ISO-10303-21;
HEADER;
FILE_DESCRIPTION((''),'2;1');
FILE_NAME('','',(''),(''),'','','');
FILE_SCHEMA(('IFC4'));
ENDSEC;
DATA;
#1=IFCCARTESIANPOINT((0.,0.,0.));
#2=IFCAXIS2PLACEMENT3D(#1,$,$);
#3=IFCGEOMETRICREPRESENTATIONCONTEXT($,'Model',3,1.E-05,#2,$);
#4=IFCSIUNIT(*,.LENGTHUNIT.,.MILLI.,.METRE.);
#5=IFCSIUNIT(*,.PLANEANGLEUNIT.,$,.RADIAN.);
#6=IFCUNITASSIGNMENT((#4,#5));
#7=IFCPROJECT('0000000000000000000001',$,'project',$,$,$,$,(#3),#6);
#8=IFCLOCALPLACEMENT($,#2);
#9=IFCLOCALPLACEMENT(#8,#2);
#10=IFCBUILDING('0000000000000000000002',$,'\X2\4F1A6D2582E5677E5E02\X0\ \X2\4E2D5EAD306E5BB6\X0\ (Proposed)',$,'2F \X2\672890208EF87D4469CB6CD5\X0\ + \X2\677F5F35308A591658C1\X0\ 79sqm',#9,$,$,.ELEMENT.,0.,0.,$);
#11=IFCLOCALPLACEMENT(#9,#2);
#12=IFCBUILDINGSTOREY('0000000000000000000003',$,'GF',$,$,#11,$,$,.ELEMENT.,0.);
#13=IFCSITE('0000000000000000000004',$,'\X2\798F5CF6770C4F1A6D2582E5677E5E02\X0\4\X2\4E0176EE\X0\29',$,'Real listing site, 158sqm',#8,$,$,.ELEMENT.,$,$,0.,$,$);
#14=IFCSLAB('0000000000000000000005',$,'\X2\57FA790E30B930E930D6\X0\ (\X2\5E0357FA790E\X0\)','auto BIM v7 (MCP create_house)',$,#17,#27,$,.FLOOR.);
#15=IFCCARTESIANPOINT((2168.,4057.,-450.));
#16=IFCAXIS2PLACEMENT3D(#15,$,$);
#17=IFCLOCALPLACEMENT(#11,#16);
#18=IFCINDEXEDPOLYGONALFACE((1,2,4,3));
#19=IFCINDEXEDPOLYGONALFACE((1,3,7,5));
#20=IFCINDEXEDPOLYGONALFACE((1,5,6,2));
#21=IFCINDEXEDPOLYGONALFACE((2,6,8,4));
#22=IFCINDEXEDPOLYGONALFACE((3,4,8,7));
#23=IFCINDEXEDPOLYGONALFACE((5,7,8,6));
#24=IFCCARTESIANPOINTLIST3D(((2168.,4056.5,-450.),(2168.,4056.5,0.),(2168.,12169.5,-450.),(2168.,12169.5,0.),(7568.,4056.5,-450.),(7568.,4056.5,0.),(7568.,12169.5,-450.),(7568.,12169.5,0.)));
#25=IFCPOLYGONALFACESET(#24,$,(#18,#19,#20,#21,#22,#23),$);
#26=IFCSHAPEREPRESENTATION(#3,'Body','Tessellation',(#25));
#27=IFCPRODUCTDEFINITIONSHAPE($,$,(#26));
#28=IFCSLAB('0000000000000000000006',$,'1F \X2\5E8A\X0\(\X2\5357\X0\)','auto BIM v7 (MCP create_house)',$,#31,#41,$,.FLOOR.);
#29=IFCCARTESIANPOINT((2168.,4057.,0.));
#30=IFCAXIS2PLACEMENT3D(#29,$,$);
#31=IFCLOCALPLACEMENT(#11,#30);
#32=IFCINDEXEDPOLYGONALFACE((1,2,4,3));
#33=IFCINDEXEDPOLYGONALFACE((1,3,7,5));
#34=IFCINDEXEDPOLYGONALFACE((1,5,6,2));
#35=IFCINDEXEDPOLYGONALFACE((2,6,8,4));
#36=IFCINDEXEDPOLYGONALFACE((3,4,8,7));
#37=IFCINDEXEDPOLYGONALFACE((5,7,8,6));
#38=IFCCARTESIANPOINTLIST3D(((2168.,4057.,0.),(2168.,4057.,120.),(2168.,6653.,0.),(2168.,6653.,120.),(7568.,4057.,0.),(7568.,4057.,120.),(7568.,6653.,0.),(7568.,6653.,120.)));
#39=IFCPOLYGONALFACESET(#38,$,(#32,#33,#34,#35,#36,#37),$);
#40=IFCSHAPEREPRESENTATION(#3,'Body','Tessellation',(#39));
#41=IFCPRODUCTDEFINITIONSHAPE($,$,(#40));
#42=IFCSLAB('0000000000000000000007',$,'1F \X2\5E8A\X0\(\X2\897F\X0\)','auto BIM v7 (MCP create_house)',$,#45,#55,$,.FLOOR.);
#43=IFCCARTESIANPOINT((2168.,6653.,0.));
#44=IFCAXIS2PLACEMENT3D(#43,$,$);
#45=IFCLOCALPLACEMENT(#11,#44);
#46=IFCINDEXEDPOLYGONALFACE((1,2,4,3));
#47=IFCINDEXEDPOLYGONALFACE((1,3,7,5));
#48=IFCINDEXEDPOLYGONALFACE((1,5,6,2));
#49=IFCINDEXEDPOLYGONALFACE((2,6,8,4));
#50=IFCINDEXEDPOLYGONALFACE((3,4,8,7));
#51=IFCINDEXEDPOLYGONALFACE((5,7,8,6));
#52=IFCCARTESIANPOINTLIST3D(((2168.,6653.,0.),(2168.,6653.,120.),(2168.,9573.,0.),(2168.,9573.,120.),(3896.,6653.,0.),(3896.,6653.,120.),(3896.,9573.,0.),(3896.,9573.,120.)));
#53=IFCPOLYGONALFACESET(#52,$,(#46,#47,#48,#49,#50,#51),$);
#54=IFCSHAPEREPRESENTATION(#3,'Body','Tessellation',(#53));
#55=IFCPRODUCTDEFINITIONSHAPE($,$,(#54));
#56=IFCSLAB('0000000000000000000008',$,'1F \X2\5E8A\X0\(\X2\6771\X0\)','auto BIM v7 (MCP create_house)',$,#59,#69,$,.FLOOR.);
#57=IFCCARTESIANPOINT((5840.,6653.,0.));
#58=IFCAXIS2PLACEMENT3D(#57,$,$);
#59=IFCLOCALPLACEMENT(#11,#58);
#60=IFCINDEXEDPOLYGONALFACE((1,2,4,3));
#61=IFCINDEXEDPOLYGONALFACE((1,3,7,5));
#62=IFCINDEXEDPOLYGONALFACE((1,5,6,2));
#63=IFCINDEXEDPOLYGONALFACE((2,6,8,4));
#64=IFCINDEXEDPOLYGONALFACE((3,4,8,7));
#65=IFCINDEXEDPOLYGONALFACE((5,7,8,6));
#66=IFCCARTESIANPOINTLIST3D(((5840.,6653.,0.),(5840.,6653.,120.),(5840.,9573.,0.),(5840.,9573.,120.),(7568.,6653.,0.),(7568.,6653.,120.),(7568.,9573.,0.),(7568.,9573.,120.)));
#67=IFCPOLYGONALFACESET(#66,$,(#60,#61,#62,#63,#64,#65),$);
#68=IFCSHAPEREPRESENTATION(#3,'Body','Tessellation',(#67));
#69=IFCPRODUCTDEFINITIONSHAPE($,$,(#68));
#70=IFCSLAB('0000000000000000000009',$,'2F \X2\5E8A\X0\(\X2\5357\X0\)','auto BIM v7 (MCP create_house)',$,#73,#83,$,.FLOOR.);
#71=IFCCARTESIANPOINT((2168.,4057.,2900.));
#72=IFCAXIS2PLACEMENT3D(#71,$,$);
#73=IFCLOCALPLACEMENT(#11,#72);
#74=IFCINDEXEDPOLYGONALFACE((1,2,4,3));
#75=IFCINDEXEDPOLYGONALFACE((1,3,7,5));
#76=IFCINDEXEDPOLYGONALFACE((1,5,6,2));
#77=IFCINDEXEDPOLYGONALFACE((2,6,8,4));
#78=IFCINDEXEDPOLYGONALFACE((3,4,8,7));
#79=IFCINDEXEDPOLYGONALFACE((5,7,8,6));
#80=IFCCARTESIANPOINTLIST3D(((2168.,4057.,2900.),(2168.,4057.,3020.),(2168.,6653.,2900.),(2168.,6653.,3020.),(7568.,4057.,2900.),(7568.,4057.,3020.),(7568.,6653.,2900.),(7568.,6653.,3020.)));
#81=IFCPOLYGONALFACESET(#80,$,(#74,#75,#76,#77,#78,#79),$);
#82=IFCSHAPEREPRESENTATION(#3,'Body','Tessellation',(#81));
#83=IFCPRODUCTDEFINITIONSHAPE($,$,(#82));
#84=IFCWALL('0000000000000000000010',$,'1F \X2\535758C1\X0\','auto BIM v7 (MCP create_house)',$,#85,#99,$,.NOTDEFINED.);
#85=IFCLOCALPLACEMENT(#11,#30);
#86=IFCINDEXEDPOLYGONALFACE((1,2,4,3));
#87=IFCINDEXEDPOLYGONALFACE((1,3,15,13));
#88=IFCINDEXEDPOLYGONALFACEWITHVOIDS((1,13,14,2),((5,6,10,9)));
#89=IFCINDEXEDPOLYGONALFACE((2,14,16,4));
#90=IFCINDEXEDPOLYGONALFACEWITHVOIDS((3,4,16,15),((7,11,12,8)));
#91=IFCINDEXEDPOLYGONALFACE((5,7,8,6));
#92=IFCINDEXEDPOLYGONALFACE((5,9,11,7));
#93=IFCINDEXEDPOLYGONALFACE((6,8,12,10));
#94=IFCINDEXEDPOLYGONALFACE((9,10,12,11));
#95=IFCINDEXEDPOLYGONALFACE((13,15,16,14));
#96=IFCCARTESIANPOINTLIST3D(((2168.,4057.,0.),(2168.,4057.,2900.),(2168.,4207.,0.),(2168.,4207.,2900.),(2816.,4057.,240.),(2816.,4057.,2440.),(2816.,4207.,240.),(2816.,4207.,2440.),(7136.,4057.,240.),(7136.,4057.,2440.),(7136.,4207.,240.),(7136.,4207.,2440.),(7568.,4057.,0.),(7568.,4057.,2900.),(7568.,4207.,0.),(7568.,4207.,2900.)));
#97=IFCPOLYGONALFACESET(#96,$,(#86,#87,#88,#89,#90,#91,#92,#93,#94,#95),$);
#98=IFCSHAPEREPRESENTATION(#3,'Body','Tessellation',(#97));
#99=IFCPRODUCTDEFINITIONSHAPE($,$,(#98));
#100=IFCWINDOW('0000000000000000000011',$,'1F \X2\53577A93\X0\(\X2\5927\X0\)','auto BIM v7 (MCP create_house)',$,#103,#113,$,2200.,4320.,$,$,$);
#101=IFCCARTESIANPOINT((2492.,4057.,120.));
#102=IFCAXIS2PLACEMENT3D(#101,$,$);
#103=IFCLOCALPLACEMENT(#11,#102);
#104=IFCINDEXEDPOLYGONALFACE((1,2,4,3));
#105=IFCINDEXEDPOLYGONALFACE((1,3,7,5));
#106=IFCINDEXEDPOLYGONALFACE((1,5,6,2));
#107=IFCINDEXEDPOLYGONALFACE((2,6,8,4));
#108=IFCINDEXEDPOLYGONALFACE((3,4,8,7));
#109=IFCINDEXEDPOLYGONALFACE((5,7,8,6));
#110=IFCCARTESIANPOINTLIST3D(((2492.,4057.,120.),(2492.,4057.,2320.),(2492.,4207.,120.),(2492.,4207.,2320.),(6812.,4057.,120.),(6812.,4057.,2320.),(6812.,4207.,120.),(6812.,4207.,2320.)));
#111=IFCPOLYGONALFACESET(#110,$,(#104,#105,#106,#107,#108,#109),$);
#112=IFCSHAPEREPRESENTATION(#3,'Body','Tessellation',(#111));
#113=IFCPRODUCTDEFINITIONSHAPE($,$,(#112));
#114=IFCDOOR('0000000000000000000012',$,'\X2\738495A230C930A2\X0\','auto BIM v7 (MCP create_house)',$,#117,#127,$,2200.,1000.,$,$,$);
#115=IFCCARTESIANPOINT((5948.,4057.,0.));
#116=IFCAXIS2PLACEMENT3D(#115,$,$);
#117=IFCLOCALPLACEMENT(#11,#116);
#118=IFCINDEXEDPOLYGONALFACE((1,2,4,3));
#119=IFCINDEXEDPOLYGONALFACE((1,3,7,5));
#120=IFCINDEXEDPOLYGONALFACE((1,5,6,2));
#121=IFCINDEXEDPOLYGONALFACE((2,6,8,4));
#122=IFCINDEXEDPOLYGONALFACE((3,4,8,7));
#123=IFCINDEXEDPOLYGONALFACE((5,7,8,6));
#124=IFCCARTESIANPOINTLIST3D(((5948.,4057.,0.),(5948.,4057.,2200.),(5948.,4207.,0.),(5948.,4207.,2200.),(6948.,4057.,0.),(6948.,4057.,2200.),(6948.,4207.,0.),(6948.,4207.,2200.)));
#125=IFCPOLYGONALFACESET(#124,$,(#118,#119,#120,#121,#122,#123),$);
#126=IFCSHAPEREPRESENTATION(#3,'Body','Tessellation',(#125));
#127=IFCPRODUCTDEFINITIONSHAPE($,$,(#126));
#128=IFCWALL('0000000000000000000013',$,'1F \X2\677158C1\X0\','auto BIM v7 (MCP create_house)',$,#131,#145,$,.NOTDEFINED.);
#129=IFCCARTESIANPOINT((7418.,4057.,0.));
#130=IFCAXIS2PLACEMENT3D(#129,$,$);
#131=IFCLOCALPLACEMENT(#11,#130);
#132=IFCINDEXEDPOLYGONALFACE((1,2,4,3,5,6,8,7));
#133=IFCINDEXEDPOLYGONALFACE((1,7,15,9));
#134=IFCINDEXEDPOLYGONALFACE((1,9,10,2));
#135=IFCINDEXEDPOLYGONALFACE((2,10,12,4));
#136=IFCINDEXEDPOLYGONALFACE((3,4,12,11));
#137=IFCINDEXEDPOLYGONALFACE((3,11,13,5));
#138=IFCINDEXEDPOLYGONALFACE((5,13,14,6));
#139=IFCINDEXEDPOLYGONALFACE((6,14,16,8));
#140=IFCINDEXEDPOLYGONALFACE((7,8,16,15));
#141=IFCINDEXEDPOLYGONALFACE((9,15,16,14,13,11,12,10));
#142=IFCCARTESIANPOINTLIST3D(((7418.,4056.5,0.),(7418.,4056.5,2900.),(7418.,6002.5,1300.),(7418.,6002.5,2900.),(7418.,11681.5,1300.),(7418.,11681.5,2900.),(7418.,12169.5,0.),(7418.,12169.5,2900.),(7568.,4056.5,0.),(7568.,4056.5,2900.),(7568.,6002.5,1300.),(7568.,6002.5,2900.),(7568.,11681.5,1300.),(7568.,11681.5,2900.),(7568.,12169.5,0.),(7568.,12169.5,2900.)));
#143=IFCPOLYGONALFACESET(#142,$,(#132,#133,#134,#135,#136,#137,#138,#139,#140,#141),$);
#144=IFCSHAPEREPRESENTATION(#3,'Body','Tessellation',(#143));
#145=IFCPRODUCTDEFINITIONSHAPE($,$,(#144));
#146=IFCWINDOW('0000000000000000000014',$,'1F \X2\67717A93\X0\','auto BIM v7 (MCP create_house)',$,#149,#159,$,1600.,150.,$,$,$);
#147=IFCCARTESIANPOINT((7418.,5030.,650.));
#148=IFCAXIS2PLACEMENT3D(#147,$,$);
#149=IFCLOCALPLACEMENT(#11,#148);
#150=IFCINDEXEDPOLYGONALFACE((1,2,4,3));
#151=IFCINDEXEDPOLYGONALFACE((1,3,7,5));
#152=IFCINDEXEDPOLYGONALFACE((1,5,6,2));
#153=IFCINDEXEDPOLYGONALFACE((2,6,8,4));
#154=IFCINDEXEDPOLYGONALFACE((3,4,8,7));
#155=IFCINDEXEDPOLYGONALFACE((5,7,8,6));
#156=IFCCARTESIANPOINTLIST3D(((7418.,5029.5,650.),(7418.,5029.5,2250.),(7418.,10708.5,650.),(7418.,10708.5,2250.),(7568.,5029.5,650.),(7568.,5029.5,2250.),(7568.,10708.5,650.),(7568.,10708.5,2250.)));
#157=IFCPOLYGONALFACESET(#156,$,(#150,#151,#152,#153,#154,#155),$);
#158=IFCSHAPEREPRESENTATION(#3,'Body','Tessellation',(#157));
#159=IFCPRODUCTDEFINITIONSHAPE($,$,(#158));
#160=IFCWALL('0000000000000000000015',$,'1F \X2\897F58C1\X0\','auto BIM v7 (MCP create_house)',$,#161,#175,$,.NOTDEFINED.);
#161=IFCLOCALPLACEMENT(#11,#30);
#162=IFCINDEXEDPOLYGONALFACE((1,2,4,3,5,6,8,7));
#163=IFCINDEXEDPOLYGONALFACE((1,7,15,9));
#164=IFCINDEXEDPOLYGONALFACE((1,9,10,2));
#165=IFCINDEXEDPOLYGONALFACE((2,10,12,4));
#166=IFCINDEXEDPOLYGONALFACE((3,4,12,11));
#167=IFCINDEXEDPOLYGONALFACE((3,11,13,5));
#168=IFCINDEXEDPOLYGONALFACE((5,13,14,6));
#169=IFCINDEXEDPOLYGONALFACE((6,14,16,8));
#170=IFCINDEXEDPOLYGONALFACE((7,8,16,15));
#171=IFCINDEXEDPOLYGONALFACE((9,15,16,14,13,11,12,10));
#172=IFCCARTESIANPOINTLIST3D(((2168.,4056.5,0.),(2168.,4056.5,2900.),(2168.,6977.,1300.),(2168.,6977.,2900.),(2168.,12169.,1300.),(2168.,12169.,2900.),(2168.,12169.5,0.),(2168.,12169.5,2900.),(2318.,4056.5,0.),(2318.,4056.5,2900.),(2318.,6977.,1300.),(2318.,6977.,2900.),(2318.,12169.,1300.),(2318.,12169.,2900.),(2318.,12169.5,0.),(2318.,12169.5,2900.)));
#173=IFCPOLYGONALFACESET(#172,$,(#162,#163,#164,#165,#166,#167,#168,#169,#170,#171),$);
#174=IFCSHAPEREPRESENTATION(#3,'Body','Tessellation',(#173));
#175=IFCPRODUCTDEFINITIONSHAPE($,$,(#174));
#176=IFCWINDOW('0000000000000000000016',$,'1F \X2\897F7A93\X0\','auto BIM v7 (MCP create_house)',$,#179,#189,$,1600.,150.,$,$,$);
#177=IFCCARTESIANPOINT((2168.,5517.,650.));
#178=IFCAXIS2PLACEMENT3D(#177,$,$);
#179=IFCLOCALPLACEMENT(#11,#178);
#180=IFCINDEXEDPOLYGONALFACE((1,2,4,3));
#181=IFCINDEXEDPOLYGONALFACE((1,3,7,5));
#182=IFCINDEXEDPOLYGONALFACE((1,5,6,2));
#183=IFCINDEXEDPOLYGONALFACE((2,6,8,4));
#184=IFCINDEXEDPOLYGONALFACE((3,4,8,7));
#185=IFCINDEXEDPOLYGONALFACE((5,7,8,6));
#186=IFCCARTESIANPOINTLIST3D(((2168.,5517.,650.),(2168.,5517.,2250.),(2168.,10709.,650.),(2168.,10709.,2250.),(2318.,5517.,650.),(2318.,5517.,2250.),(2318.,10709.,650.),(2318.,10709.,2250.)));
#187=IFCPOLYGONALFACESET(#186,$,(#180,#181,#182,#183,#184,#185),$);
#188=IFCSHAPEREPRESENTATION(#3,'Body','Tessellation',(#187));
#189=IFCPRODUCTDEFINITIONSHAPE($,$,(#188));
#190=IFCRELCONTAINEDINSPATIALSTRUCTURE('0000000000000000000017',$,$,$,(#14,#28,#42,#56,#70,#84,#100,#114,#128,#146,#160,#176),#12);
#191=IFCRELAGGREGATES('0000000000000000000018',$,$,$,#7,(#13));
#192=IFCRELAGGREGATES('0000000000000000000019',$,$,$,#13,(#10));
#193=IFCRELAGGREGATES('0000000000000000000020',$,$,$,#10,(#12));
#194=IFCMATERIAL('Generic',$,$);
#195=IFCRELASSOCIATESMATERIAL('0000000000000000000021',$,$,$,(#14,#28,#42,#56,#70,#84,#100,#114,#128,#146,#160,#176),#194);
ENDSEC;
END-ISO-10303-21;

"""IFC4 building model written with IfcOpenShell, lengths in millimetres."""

from ifc_helpers import new_model, si_unit, frame, frame_2d, origin, place, context, project, spatial, rectangle, extrude, material, element, fill, save


model = new_model("IFC4")

# Units and contexts
model_context = context("Model", 3, precision=1e-05, world=origin())
ifc_project = project(units=[si_unit("LENGTHUNIT", "METRE", prefix="MILLI"), si_unit("PLANEANGLEUNIT", "RADIAN")], contexts=[model_context])

# Site, building, storey
site_placement = place(None, origin())
site = spatial("IfcSite", under=ifc_project, at=site_placement, Name="福島県会津若松市4丁目29", ObjectType="Real listing site, 158sqm", CompositionType="ELEMENT", RefElevation=0.0)
building_placement = place(site_placement, origin())
building = spatial("IfcBuilding", under=site, at=building_placement, Name="会津若松市 中庭の家 (Proposed)", ObjectType="2F 木造軸組構法 + 板張り外壁 79sqm", CompositionType="ELEMENT", ElevationOfRefHeight=0.0, ElevationOfTerrain=0.0)
storey_placement = place(building_placement, origin())
storey = spatial("IfcBuildingStorey", under=building, at=storey_placement, Name="GF", CompositionType="ELEMENT", Elevation=0.0)

# Slabs
ifc_material = material(Name="Generic")
slab_1_placement = place(storey_placement, frame((2168.0, 4057.0, -450.0)))
element("IfcSlab", 1, at=slab_1_placement, inside=storey, material=ifc_material, Name="基礎スラブ (布基礎)", Description="auto BIM v7 (MCP create_house)", PredefinedType="FLOOR", context=model_context, shape_type="SweptSolid", body=[
    extrude(rectangle(XDim=5400.0, YDim=8113.0, at=frame_2d((2700.0, 4056.0))), frame((2168.0, 4057.0, -450.0)), (0.0, 0.0, 1.0), 450.0),
])
slab_2_placement = place(storey_placement, frame((2168.0, 4057.0, 0.0)))
element("IfcSlab", 2, at=slab_2_placement, inside=storey, material=ifc_material, Name="1F 床(南)", Description="auto BIM v7 (MCP create_house)", PredefinedType="FLOOR", context=model_context, shape_type="SweptSolid", body=[
    extrude(rectangle(XDim=5400.0, YDim=2596.0, at=frame_2d((2700.0, 1298.0))), frame((2168.0, 4057.0, 0.0)), (0.0, 0.0, 1.0), 120.0),
])
slab_3_placement = place(storey_placement, frame((2168.0, 6653.0, 0.0)))
element("IfcSlab", 3, at=slab_3_placement, inside=storey, material=ifc_material, Name="1F 床(西)", Description="auto BIM v7 (MCP create_house)", PredefinedType="FLOOR", context=model_context, shape_type="SweptSolid", body=[
    extrude(rectangle(XDim=1728.0, YDim=2920.0, at=frame_2d((864.0, 1460.0))), frame((2168.0, 6653.0, 0.0)), (0.0, 0.0, 1.0), 120.0),
])
slab_4_placement = place(storey_placement, frame((5840.0, 6653.0, 0.0)))
element("IfcSlab", 4, at=slab_4_placement, inside=storey, material=ifc_material, Name="1F 床(東)", Description="auto BIM v7 (MCP create_house)", PredefinedType="FLOOR", context=model_context, shape_type="SweptSolid", body=[
    extrude(rectangle(XDim=1728.0, YDim=2920.0, at=frame_2d((864.0, 1460.0))), frame((5840.0, 6653.0, 0.0)), (0.0, 0.0, 1.0), 120.0),
])
slab_5_placement = place(storey_placement, frame((2168.0, 4057.0, 2900.0)))
element("IfcSlab", 5, at=slab_5_placement, inside=storey, material=ifc_material, Name="2F 床(南)", Description="auto BIM v7 (MCP create_house)", PredefinedType="FLOOR", context=model_context, shape_type="SweptSolid", body=[
    extrude(rectangle(XDim=5400.0, YDim=2596.0, at=frame_2d((2700.0, 1298.0))), frame((2168.0, 4057.0, 2900.0)), (0.0, 0.0, 1.0), 120.0),
])

# Wall, openings, window, door
wall_1_placement = place(storey_placement, frame((2168.0, 4057.0, 0.0)))
wall_1 = element("IfcWall", 6, at=wall_1_placement, inside=storey, material=ifc_material, Name="1F 南壁", Description="auto BIM v7 (MCP create_house)", PredefinedType="NOTDEFINED", context=model_context, shape_type="SweptSolid", body=[
    extrude(rectangle(XDim=5400.0, YDim=150.0, at=frame_2d((2700.0, 75.0))), frame((2168.0, 4057.0, 0.0)), (0.0, 0.0, 1.0), 2900.0),
])
opening_1_placement = place(storey_placement, frame((2492.0, 4057.0, 120.0)))
opening_1 = element("IfcOpeningElement", 7, at=opening_1_placement, cuts=wall_1, PredefinedType="NOTDEFINED", context=model_context, shape_type="SweptSolid", body=[
    extrude(rectangle(XDim=4320.0, YDim=150.0, at=frame_2d((2160.0, 75.0))), frame((2492.0, 4057.0, 120.0)), (0.0, 0.0, 1.0), 2200.0),
])
opening_2_placement = place(storey_placement, frame((5948.0, 4057.0, 0.0)))
opening_2 = element("IfcOpeningElement", 8, at=opening_2_placement, cuts=wall_1, PredefinedType="NOTDEFINED", context=model_context, shape_type="SweptSolid", body=[
    extrude(rectangle(XDim=1000.0, YDim=150.0, at=frame_2d((500.0, 75.0))), frame((5948.0, 4057.0, 0.0)), (0.0, 0.0, 1.0), 2200.0),
])
window_1_placement = place(storey_placement, frame((2492.0, 4057.0, 120.0)))
window_1 = element("IfcWindow", 9, at=window_1_placement, inside=storey, material=ifc_material, Name="1F 南窓(大)", Description="auto BIM v7 (MCP create_house)", OverallHeight=2200.0, OverallWidth=4320.0, context=model_context, shape_type="SweptSolid", body=[
    extrude(rectangle(XDim=4320.0, YDim=150.0, at=frame_2d((2160.0, 75.0))), frame((2492.0, 4057.0, 120.0)), (0.0, 0.0, 1.0), 2200.0),
])
fill(opening_1, window_1)
door_placement = place(storey_placement, frame((5948.0, 4057.0, 0.0)))
door = element("IfcDoor", 10, at=door_placement, inside=storey, material=ifc_material, Name="玄関ドア", Description="auto BIM v7 (MCP create_house)", OverallHeight=2200.0, OverallWidth=1000.0, context=model_context, shape_type="SweptSolid", body=[
    extrude(rectangle(XDim=1000.0, YDim=150.0, at=frame_2d((500.0, 75.0))), frame((5948.0, 4057.0, 0.0)), (0.0, 0.0, 1.0), 2200.0),
])
fill(opening_2, door)

# Walls, openings, windows
wall_2_placement = place(storey_placement, frame((7418.0, 4057.0, 0.0)))
wall_2 = element("IfcWall", 11, at=wall_2_placement, inside=storey, material=ifc_material, Name="1F 東壁", Description="auto BIM v7 (MCP create_house)", PredefinedType="NOTDEFINED", context=model_context, shape_type="SweptSolid", body=[
    extrude(rectangle(XDim=150.0, YDim=8113.0, at=frame_2d((75.0, 4056.0))), frame((7418.0, 4057.0, 0.0)), (0.0, 0.0, 1.0), 2900.0),
])
opening_3_placement = place(storey_placement, frame((7418.0, 5030.0, 650.0)))
opening_3 = element("IfcOpeningElement", 12, at=opening_3_placement, cuts=wall_2, PredefinedType="NOTDEFINED", context=model_context, shape_type="SweptSolid", body=[
    extrude(rectangle(XDim=150.0, YDim=5679.0, at=frame_2d((75.0, 2839.0))), frame((7418.0, 5030.0, 650.0)), (0.0, 0.0, 1.0), 1600.0),
])
window_2_placement = place(storey_placement, frame((7418.0, 5030.0, 650.0)))
window_2 = element("IfcWindow", 13, at=window_2_placement, inside=storey, material=ifc_material, Name="1F 東窓", Description="auto BIM v7 (MCP create_house)", OverallHeight=1600.0, OverallWidth=150.0, context=model_context, shape_type="SweptSolid", body=[
    extrude(rectangle(XDim=150.0, YDim=5679.0, at=frame_2d((75.0, 2839.0))), frame((7418.0, 5030.0, 650.0)), (0.0, 0.0, 1.0), 1600.0),
])
fill(opening_3, window_2)
wall_3_placement = place(storey_placement, frame((2168.0, 4057.0, 0.0)))
wall_3 = element("IfcWall", 14, at=wall_3_placement, inside=storey, material=ifc_material, Name="1F 西壁", Description="auto BIM v7 (MCP create_house)", PredefinedType="NOTDEFINED", context=model_context, shape_type="SweptSolid", body=[
    extrude(rectangle(XDim=150.0, YDim=8113.0, at=frame_2d((75.0, 4056.0))), frame((2168.0, 4057.0, 0.0)), (0.0, 0.0, 1.0), 2900.0),
])
opening_4_placement = place(storey_placement, frame((2168.0, 5517.0, 650.0)))
opening_4 = element("IfcOpeningElement", 15, at=opening_4_placement, cuts=wall_3, PredefinedType="NOTDEFINED", context=model_context, shape_type="SweptSolid", body=[
    extrude(rectangle(XDim=150.0, YDim=5192.0, at=frame_2d((75.0, 2596.0))), frame((2168.0, 5517.0, 650.0)), (0.0, 0.0, 1.0), 1600.0),
])
window_3_placement = place(storey_placement, frame((2168.0, 5517.0, 650.0)))
window_3 = element("IfcWindow", 16, at=window_3_placement, inside=storey, material=ifc_material, Name="1F 西窓", Description="auto BIM v7 (MCP create_house)", OverallHeight=1600.0, OverallWidth=150.0, context=model_context, shape_type="SweptSolid", body=[
    extrude(rectangle(XDim=150.0, YDim=5192.0, at=frame_2d((75.0, 2596.0))), frame((2168.0, 5517.0, 650.0)), (0.0, 0.0, 1.0), 1600.0),
])
fill(opening_4, window_3)

save(model, "model.ifc")
